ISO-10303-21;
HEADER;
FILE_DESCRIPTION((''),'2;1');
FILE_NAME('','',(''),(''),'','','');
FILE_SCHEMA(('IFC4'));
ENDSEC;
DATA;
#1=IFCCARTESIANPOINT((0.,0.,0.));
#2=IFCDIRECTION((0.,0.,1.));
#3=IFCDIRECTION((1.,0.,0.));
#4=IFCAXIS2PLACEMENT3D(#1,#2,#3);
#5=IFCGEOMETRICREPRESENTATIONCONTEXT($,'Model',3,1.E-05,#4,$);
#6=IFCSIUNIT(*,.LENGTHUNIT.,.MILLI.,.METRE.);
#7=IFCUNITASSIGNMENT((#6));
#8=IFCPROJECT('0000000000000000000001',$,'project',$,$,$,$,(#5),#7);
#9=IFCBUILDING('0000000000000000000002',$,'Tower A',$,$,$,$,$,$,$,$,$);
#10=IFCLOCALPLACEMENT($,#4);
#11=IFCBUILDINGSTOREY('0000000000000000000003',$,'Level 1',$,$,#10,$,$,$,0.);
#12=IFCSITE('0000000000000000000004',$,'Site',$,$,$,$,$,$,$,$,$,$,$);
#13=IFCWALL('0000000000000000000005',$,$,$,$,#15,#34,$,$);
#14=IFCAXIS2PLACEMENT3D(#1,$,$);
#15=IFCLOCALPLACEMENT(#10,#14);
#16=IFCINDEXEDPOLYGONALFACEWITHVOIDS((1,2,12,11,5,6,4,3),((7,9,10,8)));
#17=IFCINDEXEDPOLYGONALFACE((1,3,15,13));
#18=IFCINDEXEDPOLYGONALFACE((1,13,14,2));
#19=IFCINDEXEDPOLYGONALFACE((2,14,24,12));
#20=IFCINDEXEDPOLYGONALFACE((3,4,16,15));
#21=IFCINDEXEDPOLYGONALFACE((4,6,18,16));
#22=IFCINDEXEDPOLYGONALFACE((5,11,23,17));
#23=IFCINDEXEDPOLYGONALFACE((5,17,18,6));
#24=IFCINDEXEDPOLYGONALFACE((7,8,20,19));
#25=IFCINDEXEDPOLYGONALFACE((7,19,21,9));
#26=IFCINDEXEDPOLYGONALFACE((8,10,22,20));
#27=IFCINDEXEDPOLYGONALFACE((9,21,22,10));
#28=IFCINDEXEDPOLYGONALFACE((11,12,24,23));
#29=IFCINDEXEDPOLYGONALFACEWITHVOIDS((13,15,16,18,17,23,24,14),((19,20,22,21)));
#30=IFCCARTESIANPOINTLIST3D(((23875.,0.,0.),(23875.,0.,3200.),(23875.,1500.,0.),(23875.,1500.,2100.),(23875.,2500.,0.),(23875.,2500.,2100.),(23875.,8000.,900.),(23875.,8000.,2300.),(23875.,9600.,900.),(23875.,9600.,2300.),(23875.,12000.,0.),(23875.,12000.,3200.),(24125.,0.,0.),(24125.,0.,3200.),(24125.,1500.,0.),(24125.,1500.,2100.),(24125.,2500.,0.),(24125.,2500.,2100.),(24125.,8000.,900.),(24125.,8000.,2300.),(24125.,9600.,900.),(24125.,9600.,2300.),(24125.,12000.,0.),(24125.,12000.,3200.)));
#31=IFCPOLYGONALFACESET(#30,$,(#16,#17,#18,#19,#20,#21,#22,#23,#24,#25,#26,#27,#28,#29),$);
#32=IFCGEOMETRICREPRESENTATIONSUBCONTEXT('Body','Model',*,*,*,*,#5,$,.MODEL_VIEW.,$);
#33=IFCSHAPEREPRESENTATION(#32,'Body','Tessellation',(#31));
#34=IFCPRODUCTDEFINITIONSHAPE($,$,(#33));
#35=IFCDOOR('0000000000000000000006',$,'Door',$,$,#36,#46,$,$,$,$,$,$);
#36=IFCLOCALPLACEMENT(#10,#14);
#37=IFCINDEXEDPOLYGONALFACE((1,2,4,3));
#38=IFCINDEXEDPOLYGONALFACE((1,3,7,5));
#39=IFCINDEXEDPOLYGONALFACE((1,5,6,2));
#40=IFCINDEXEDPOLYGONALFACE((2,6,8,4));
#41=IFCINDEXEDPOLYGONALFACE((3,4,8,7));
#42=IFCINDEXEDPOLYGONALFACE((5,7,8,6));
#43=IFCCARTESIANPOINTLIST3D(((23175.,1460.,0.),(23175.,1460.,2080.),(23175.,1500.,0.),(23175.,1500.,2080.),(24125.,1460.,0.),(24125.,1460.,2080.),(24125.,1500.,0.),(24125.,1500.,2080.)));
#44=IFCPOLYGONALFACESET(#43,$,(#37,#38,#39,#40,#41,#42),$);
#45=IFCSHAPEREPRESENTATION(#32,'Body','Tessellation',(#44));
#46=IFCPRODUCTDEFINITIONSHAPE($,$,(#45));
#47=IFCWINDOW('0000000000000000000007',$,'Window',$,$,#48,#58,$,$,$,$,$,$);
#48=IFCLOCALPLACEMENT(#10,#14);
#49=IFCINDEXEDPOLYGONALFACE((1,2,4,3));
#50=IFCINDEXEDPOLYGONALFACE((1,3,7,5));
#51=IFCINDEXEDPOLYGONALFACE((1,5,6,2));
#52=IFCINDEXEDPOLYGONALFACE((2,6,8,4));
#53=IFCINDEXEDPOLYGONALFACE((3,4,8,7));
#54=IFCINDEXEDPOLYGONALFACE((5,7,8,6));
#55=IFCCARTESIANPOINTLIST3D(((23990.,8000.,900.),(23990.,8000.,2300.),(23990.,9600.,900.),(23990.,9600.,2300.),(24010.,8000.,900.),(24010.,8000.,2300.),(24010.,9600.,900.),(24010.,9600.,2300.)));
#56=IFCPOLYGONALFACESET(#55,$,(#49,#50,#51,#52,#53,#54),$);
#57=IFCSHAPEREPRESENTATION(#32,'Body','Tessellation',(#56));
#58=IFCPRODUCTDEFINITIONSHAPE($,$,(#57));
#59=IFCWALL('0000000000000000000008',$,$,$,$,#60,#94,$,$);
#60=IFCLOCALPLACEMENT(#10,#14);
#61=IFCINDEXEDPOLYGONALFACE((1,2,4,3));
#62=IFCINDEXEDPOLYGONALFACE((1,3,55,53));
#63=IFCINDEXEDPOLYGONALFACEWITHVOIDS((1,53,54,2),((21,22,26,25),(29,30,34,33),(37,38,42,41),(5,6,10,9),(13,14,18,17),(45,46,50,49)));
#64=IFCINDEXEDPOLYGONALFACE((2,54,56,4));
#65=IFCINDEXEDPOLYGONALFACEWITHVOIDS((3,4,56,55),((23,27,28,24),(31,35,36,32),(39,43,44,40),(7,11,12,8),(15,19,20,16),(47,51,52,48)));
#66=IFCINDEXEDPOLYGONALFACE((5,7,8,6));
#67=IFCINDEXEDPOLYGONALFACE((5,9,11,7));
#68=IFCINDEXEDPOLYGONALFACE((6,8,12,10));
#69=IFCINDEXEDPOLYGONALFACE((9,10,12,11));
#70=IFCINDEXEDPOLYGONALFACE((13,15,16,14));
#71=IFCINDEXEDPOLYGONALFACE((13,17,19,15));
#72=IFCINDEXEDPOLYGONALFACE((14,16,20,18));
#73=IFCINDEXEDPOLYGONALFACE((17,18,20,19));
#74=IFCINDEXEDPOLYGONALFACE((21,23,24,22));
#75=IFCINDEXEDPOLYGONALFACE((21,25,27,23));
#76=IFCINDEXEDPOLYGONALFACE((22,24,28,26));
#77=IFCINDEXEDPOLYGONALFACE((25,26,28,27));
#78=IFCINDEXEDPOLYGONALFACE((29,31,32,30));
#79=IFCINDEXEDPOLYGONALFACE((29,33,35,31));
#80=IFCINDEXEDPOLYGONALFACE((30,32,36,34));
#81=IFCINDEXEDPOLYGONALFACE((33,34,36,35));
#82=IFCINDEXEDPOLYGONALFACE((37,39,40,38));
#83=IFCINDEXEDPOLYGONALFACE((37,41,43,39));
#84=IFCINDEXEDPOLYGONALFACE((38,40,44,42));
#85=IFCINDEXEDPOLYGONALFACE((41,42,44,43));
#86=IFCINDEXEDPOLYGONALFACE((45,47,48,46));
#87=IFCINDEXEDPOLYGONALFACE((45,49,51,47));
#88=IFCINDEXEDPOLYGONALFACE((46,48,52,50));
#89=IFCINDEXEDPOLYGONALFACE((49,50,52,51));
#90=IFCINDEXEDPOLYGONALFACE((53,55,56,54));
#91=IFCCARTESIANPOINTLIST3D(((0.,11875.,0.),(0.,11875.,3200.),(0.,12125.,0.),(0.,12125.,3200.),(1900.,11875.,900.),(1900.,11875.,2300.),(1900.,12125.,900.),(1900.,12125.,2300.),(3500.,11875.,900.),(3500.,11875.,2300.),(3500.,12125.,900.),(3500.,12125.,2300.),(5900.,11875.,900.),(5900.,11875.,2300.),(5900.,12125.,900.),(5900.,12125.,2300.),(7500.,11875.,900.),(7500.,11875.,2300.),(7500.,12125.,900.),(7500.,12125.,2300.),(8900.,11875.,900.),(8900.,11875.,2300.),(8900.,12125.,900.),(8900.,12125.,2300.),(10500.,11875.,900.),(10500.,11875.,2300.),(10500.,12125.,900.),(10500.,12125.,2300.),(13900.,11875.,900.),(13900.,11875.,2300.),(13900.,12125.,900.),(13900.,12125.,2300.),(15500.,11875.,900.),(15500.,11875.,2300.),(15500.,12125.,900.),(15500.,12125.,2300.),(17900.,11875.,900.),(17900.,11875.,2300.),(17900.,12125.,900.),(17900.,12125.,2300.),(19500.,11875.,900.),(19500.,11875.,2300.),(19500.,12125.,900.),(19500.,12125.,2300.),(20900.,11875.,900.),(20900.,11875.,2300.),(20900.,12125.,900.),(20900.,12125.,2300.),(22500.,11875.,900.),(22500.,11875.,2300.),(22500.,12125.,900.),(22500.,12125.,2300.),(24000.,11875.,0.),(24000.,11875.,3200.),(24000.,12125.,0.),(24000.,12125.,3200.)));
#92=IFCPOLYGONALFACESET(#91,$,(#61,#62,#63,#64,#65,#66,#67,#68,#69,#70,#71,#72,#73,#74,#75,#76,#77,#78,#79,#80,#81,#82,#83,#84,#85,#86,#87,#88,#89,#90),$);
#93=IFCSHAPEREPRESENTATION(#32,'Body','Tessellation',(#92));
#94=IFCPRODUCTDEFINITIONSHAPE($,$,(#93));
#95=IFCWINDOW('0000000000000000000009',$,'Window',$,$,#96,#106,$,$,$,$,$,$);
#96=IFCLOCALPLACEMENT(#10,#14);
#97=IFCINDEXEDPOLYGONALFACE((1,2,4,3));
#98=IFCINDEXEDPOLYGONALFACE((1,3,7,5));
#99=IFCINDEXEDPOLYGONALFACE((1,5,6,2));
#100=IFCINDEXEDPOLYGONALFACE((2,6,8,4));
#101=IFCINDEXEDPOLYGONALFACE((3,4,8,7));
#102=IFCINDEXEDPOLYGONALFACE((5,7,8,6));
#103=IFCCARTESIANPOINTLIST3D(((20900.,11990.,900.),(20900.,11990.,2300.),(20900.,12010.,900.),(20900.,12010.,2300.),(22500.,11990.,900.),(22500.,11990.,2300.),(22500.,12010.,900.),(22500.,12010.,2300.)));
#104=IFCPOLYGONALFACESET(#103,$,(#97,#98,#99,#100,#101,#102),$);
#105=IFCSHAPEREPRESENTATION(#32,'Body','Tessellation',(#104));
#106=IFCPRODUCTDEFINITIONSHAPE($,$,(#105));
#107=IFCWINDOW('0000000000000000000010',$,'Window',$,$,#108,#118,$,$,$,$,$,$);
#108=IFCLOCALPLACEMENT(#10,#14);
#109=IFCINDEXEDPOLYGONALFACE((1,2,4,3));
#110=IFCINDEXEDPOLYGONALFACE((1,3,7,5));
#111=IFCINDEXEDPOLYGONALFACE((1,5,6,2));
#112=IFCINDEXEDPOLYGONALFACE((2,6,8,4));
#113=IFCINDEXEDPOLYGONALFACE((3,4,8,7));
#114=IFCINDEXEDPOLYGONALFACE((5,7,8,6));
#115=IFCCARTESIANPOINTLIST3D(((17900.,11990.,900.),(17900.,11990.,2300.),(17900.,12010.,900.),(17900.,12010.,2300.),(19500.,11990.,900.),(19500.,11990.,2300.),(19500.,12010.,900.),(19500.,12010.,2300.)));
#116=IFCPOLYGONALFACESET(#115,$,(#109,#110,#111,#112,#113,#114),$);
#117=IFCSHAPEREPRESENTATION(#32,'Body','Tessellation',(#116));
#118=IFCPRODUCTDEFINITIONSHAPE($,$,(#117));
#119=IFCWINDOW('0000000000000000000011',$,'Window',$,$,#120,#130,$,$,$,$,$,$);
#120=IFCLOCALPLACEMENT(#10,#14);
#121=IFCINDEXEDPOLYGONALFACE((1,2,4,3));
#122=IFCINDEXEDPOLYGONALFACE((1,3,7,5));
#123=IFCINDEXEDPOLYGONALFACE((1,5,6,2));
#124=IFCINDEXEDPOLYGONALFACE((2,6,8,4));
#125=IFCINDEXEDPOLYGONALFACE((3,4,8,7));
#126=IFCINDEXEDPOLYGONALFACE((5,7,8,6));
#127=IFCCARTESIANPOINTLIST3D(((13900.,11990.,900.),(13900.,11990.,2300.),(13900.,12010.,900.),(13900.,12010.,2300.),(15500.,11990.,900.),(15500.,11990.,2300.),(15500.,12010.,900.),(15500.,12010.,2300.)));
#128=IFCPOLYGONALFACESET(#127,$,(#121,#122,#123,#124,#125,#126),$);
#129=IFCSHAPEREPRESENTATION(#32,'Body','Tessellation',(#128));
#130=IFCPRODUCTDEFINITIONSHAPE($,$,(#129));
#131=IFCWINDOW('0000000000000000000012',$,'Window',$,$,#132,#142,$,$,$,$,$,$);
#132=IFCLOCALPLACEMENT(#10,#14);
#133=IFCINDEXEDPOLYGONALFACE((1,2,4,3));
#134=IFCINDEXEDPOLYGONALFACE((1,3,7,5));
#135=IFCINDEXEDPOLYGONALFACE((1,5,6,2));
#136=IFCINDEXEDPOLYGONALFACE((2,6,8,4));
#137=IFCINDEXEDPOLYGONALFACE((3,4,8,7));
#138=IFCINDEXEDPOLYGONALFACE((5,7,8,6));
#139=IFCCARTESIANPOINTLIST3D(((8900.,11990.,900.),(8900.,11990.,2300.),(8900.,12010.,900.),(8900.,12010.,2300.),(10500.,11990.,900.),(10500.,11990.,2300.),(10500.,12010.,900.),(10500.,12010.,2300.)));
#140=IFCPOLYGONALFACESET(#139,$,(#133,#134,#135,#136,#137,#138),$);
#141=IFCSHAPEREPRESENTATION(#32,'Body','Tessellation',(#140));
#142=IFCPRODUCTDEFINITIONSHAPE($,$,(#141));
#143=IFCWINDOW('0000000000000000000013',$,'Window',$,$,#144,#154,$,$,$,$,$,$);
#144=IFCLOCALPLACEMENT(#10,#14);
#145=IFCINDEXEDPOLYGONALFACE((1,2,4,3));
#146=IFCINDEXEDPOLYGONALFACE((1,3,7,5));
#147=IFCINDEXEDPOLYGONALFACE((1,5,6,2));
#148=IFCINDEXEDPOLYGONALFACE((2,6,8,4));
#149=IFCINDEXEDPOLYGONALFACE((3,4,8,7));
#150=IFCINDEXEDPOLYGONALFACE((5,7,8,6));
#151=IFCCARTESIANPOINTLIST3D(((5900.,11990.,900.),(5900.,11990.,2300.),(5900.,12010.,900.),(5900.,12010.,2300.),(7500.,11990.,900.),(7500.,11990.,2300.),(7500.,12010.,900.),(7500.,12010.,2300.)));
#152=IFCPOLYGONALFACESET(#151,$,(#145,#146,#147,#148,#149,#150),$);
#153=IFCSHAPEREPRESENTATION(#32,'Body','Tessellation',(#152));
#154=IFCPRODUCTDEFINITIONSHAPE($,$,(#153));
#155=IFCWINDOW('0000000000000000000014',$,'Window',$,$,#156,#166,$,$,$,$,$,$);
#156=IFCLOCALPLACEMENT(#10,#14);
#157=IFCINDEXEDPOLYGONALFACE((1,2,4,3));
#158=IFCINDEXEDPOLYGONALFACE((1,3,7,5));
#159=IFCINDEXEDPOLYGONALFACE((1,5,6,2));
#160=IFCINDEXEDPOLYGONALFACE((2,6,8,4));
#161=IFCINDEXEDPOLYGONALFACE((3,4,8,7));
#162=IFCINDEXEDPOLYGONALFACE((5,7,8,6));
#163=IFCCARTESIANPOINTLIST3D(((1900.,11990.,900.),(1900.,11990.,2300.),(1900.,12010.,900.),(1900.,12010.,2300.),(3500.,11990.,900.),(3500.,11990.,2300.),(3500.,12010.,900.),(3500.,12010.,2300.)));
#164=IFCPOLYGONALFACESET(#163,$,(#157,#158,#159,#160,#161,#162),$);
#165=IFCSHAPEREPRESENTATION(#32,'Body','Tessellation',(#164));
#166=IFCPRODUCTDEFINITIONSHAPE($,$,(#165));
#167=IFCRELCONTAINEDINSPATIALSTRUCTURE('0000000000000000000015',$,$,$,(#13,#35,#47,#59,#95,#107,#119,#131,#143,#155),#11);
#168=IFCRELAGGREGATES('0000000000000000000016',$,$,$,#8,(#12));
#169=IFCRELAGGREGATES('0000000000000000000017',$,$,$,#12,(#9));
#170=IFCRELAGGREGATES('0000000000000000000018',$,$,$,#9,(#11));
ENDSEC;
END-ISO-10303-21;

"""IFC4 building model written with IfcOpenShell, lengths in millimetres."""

from ifc_helpers import new_model, si_unit, frame, origin_with_axes, place, context, subcontext, project, spatial, indexed_curve, outline, extrude, element, fill, save


model = new_model("IFC4")

# Units and contexts
model_context = context("Model", 3, precision=1e-05, world=origin_with_axes())
body_context = subcontext(model_context, "Body", "Model", "MODEL_VIEW")
ifc_project = project(units=[si_unit("LENGTHUNIT", "METRE", prefix="MILLI")], contexts=[model_context])

# Site, building, storey
site = spatial("IfcSite", under=ifc_project, Name="Site")
building = spatial("IfcBuilding", under=site, Name="Tower A")
storey_placement = place(None, origin_with_axes())
storey = spatial("IfcBuildingStorey", under=building, at=storey_placement, Name="Level 1", Elevation=0.0)

# Wall, openings, door, window
wall_1_placement = place(storey_placement, frame((24125.0, 0.0, 0.0), z_axis=(0.0, 0.0, 1.0), x_axis=(0.0, 1.0, 0.0)))
wall_1 = element("IfcWall", 1, at=wall_1_placement, inside=storey, context=body_context, shape_type="SweptSolid", body=[
    extrude(outline(indexed_curve([(0.0, 0.0), (0.0, 250.0), (12000.0, 250.0), (12000.0, 0.0), (0.0, 0.0)], self_intersect=False)), origin_with_axes(), (0.0, 0.0, 1.0), 3200.0),
])
opening_1_placement = place(wall_1_placement, frame((1500.0, 0.0, 0.0), z_axis=(0.0, 0.0, 1.0), x_axis=(1.0, 0.0, 0.0)))
opening_1 = element("IfcOpeningElement", 2, at=opening_1_placement, cuts=wall_1, context=body_context, shape_type="SweptSolid", body=[
    extrude(outline(indexed_curve([(0.0, 0.0), (0.0, 250.0), (1000.0, 250.0), (1000.0, 0.0), (0.0, 0.0)], self_intersect=False)), origin_with_axes(), (0.0, 0.0, 1.0), 2100.0),
])
opening_2_placement = place(wall_1_placement, frame((8000.0, 0.0, 900.0), z_axis=(0.0, 0.0, 1.0), x_axis=(1.0, 0.0, 0.0)))
opening_2 = element("IfcOpeningElement", 3, at=opening_2_placement, cuts=wall_1, context=body_context, shape_type="SweptSolid", body=[
    extrude(outline(indexed_curve([(0.0, 0.0), (0.0, 250.0), (1600.0, 250.0), (1600.0, 0.0), (0.0, 0.0)], self_intersect=False)), origin_with_axes(), (0.0, 0.0, 1.0), 1400.0),
])
door_1_placement = place(storey_placement, frame((24125.0, 1500.0, 0.0), z_axis=(0.0, 0.0, 1.0), x_axis=(-1.0, 0.0, 0.0)))
door_1 = element("IfcDoor", 4, at=door_1_placement, inside=storey, Name="Door", context=body_context, shape_type="SweptSolid", body=[
    extrude(outline(indexed_curve([(0.0, 0.0), (0.0, 40.0), (950.0, 40.0), (950.0, 0.0), (0.0, 0.0)], self_intersect=False)), origin_with_axes(), (0.0, 0.0, 1.0), 2080.0),
])
fill(opening_1, door_1)
window_1_placement = place(storey_placement, frame((24010.0, 8000.0, 900.0), z_axis=(0.0, 0.0, 1.0), x_axis=(0.0, 1.0, 0.0)))
window_1 = element("IfcWindow", 5, at=window_1_placement, inside=storey, Name="Window", context=body_context, shape_type="SweptSolid", body=[
    extrude(outline(indexed_curve([(0.0, 0.0), (0.0, 20.0), (1600.0, 20.0), (1600.0, 0.0), (0.0, 0.0)], self_intersect=False)), origin_with_axes(), (0.0, 0.0, 1.0), 1400.0),
])
fill(opening_2, window_1)

# Wall, openings, windows
wall_2_placement = place(storey_placement, frame((24000.0, 12125.0, 0.0), z_axis=(0.0, 0.0, 1.0), x_axis=(-1.0, 0.0, 0.0)))
wall_2 = element("IfcWall", 6, at=wall_2_placement, inside=storey, context=body_context, shape_type="SweptSolid", body=[
    extrude(outline(indexed_curve([(0.0, 0.0), (0.0, 250.0), (24000.0, 250.0), (24000.0, 0.0), (0.0, 0.0)], self_intersect=False)), origin_with_axes(), (0.0, 0.0, 1.0), 3200.0),
])
opening_3_placement = place(wall_2_placement, frame((1500.0, 0.0, 900.0), z_axis=(0.0, 0.0, 1.0), x_axis=(1.0, 0.0, 0.0)))
opening_3 = element("IfcOpeningElement", 7, at=opening_3_placement, cuts=wall_2, context=body_context, shape_type="SweptSolid", body=[
    extrude(outline(indexed_curve([(0.0, 0.0), (0.0, 250.0), (1600.0, 250.0), (1600.0, 0.0), (0.0, 0.0)], self_intersect=False)), origin_with_axes(), (0.0, 0.0, 1.0), 1400.0),
])
opening_4_placement = place(wall_2_placement, frame((4500.0, 0.0, 900.0), z_axis=(0.0, 0.0, 1.0), x_axis=(1.0, 0.0, 0.0)))
opening_4 = element("IfcOpeningElement", 8, at=opening_4_placement, cuts=wall_2, context=body_context, shape_type="SweptSolid", body=[
    extrude(outline(indexed_curve([(0.0, 0.0), (0.0, 250.0), (1600.0, 250.0), (1600.0, 0.0), (0.0, 0.0)], self_intersect=False)), origin_with_axes(), (0.0, 0.0, 1.0), 1400.0),
])
opening_5_placement = place(wall_2_placement, frame((8500.0, 0.0, 900.0), z_axis=(0.0, 0.0, 1.0), x_axis=(1.0, 0.0, 0.0)))
opening_5 = element("IfcOpeningElement", 9, at=opening_5_placement, cuts=wall_2, context=body_context, shape_type="SweptSolid", body=[
    extrude(outline(indexed_curve([(0.0, 0.0), (0.0, 250.0), (1600.0, 250.0), (1600.0, 0.0), (0.0, 0.0)], self_intersect=False)), origin_with_axes(), (0.0, 0.0, 1.0), 1400.0),
])
opening_6_placement = place(wall_2_placement, frame((13500.0, 0.0, 900.0), z_axis=(0.0, 0.0, 1.0), x_axis=(1.0, 0.0, 0.0)))
opening_6 = element("IfcOpeningElement", 10, at=opening_6_placement, cuts=wall_2, context=body_context, shape_type="SweptSolid", body=[
    extrude(outline(indexed_curve([(0.0, 0.0), (0.0, 250.0), (1600.0, 250.0), (1600.0, 0.0), (0.0, 0.0)], self_intersect=False)), origin_with_axes(), (0.0, 0.0, 1.0), 1400.0),
])
opening_7_placement = place(wall_2_placement, frame((16500.0, 0.0, 900.0), z_axis=(0.0, 0.0, 1.0), x_axis=(1.0, 0.0, 0.0)))
opening_7 = element("IfcOpeningElement", 11, at=opening_7_placement, cuts=wall_2, context=body_context, shape_type="SweptSolid", body=[
    extrude(outline(indexed_curve([(0.0, 0.0), (0.0, 250.0), (1600.0, 250.0), (1600.0, 0.0), (0.0, 0.0)], self_intersect=False)), origin_with_axes(), (0.0, 0.0, 1.0), 1400.0),
])
opening_8_placement = place(wall_2_placement, frame((20500.0, 0.0, 900.0), z_axis=(0.0, 0.0, 1.0), x_axis=(1.0, 0.0, 0.0)))
opening_8 = element("IfcOpeningElement", 12, at=opening_8_placement, cuts=wall_2, context=body_context, shape_type="SweptSolid", body=[
    extrude(outline(indexed_curve([(0.0, 0.0), (0.0, 250.0), (1600.0, 250.0), (1600.0, 0.0), (0.0, 0.0)], self_intersect=False)), origin_with_axes(), (0.0, 0.0, 1.0), 1400.0),
])
window_2_placement = place(storey_placement, frame((22500.0, 12010.0, 900.0), z_axis=(0.0, 0.0, 1.0), x_axis=(-1.0, 0.0, 0.0)))
window_2 = element("IfcWindow", 13, at=window_2_placement, inside=storey, Name="Window", context=body_context, shape_type="SweptSolid", body=[
    extrude(outline(indexed_curve([(0.0, 0.0), (0.0, 20.0), (1600.0, 20.0), (1600.0, 0.0), (0.0, 0.0)], self_intersect=False)), origin_with_axes(), (0.0, 0.0, 1.0), 1400.0),
])
fill(opening_3, window_2)
window_3_placement = place(storey_placement, frame((19500.0, 12010.0, 900.0), z_axis=(0.0, 0.0, 1.0), x_axis=(-1.0, 0.0, 0.0)))
window_3 = element("IfcWindow", 14, at=window_3_placement, inside=storey, Name="Window", context=body_context, shape_type="SweptSolid", body=[
    extrude(outline(indexed_curve([(0.0, 0.0), (0.0, 20.0), (1600.0, 20.0), (1600.0, 0.0), (0.0, 0.0)], self_intersect=False)), origin_with_axes(), (0.0, 0.0, 1.0), 1400.0),
])
fill(opening_4, window_3)
window_4_placement = place(storey_placement, frame((15500.0, 12010.0, 900.0), z_axis=(0.0, 0.0, 1.0), x_axis=(-1.0, 0.0, 0.0)))
window_4 = element("IfcWindow", 15, at=window_4_placement, inside=storey, Name="Window", context=body_context, shape_type="SweptSolid", body=[
    extrude(outline(indexed_curve([(0.0, 0.0), (0.0, 20.0), (1600.0, 20.0), (1600.0, 0.0), (0.0, 0.0)], self_intersect=False)), origin_with_axes(), (0.0, 0.0, 1.0), 1400.0),
])
fill(opening_5, window_4)
window_5_placement = place(storey_placement, frame((10500.0, 12010.0, 900.0), z_axis=(0.0, 0.0, 1.0), x_axis=(-1.0, 0.0, 0.0)))
window_5 = element("IfcWindow", 16, at=window_5_placement, inside=storey, Name="Window", context=body_context, shape_type="SweptSolid", body=[
    extrude(outline(indexed_curve([(0.0, 0.0), (0.0, 20.0), (1600.0, 20.0), (1600.0, 0.0), (0.0, 0.0)], self_intersect=False)), origin_with_axes(), (0.0, 0.0, 1.0), 1400.0),
])
fill(opening_6, window_5)
window_6_placement = place(storey_placement, frame((7500.0, 12010.0, 900.0), z_axis=(0.0, 0.0, 1.0), x_axis=(-1.0, 0.0, 0.0)))
window_6 = element("IfcWindow", 17, at=window_6_placement, inside=storey, Name="Window", context=body_context, shape_type="SweptSolid", body=[
    extrude(outline(indexed_curve([(0.0, 0.0), (0.0, 20.0), (1600.0, 20.0), (1600.0, 0.0), (0.0, 0.0)], self_intersect=False)), origin_with_axes(), (0.0, 0.0, 1.0), 1400.0),
])
fill(opening_7, window_6)
window_7_placement = place(storey_placement, frame((3500.0, 12010.0, 900.0), z_axis=(0.0, 0.0, 1.0), x_axis=(-1.0, 0.0, 0.0)))
window_7 = element("IfcWindow", 18, at=window_7_placement, inside=storey, Name="Window", context=body_context, shape_type="SweptSolid", body=[
    extrude(outline(indexed_curve([(0.0, 0.0), (0.0, 20.0), (1600.0, 20.0), (1600.0, 0.0), (0.0, 0.0)], self_intersect=False)), origin_with_axes(), (0.0, 0.0, 1.0), 1400.0),
])
fill(opening_8, window_7)

save(model, "model.ifc")
